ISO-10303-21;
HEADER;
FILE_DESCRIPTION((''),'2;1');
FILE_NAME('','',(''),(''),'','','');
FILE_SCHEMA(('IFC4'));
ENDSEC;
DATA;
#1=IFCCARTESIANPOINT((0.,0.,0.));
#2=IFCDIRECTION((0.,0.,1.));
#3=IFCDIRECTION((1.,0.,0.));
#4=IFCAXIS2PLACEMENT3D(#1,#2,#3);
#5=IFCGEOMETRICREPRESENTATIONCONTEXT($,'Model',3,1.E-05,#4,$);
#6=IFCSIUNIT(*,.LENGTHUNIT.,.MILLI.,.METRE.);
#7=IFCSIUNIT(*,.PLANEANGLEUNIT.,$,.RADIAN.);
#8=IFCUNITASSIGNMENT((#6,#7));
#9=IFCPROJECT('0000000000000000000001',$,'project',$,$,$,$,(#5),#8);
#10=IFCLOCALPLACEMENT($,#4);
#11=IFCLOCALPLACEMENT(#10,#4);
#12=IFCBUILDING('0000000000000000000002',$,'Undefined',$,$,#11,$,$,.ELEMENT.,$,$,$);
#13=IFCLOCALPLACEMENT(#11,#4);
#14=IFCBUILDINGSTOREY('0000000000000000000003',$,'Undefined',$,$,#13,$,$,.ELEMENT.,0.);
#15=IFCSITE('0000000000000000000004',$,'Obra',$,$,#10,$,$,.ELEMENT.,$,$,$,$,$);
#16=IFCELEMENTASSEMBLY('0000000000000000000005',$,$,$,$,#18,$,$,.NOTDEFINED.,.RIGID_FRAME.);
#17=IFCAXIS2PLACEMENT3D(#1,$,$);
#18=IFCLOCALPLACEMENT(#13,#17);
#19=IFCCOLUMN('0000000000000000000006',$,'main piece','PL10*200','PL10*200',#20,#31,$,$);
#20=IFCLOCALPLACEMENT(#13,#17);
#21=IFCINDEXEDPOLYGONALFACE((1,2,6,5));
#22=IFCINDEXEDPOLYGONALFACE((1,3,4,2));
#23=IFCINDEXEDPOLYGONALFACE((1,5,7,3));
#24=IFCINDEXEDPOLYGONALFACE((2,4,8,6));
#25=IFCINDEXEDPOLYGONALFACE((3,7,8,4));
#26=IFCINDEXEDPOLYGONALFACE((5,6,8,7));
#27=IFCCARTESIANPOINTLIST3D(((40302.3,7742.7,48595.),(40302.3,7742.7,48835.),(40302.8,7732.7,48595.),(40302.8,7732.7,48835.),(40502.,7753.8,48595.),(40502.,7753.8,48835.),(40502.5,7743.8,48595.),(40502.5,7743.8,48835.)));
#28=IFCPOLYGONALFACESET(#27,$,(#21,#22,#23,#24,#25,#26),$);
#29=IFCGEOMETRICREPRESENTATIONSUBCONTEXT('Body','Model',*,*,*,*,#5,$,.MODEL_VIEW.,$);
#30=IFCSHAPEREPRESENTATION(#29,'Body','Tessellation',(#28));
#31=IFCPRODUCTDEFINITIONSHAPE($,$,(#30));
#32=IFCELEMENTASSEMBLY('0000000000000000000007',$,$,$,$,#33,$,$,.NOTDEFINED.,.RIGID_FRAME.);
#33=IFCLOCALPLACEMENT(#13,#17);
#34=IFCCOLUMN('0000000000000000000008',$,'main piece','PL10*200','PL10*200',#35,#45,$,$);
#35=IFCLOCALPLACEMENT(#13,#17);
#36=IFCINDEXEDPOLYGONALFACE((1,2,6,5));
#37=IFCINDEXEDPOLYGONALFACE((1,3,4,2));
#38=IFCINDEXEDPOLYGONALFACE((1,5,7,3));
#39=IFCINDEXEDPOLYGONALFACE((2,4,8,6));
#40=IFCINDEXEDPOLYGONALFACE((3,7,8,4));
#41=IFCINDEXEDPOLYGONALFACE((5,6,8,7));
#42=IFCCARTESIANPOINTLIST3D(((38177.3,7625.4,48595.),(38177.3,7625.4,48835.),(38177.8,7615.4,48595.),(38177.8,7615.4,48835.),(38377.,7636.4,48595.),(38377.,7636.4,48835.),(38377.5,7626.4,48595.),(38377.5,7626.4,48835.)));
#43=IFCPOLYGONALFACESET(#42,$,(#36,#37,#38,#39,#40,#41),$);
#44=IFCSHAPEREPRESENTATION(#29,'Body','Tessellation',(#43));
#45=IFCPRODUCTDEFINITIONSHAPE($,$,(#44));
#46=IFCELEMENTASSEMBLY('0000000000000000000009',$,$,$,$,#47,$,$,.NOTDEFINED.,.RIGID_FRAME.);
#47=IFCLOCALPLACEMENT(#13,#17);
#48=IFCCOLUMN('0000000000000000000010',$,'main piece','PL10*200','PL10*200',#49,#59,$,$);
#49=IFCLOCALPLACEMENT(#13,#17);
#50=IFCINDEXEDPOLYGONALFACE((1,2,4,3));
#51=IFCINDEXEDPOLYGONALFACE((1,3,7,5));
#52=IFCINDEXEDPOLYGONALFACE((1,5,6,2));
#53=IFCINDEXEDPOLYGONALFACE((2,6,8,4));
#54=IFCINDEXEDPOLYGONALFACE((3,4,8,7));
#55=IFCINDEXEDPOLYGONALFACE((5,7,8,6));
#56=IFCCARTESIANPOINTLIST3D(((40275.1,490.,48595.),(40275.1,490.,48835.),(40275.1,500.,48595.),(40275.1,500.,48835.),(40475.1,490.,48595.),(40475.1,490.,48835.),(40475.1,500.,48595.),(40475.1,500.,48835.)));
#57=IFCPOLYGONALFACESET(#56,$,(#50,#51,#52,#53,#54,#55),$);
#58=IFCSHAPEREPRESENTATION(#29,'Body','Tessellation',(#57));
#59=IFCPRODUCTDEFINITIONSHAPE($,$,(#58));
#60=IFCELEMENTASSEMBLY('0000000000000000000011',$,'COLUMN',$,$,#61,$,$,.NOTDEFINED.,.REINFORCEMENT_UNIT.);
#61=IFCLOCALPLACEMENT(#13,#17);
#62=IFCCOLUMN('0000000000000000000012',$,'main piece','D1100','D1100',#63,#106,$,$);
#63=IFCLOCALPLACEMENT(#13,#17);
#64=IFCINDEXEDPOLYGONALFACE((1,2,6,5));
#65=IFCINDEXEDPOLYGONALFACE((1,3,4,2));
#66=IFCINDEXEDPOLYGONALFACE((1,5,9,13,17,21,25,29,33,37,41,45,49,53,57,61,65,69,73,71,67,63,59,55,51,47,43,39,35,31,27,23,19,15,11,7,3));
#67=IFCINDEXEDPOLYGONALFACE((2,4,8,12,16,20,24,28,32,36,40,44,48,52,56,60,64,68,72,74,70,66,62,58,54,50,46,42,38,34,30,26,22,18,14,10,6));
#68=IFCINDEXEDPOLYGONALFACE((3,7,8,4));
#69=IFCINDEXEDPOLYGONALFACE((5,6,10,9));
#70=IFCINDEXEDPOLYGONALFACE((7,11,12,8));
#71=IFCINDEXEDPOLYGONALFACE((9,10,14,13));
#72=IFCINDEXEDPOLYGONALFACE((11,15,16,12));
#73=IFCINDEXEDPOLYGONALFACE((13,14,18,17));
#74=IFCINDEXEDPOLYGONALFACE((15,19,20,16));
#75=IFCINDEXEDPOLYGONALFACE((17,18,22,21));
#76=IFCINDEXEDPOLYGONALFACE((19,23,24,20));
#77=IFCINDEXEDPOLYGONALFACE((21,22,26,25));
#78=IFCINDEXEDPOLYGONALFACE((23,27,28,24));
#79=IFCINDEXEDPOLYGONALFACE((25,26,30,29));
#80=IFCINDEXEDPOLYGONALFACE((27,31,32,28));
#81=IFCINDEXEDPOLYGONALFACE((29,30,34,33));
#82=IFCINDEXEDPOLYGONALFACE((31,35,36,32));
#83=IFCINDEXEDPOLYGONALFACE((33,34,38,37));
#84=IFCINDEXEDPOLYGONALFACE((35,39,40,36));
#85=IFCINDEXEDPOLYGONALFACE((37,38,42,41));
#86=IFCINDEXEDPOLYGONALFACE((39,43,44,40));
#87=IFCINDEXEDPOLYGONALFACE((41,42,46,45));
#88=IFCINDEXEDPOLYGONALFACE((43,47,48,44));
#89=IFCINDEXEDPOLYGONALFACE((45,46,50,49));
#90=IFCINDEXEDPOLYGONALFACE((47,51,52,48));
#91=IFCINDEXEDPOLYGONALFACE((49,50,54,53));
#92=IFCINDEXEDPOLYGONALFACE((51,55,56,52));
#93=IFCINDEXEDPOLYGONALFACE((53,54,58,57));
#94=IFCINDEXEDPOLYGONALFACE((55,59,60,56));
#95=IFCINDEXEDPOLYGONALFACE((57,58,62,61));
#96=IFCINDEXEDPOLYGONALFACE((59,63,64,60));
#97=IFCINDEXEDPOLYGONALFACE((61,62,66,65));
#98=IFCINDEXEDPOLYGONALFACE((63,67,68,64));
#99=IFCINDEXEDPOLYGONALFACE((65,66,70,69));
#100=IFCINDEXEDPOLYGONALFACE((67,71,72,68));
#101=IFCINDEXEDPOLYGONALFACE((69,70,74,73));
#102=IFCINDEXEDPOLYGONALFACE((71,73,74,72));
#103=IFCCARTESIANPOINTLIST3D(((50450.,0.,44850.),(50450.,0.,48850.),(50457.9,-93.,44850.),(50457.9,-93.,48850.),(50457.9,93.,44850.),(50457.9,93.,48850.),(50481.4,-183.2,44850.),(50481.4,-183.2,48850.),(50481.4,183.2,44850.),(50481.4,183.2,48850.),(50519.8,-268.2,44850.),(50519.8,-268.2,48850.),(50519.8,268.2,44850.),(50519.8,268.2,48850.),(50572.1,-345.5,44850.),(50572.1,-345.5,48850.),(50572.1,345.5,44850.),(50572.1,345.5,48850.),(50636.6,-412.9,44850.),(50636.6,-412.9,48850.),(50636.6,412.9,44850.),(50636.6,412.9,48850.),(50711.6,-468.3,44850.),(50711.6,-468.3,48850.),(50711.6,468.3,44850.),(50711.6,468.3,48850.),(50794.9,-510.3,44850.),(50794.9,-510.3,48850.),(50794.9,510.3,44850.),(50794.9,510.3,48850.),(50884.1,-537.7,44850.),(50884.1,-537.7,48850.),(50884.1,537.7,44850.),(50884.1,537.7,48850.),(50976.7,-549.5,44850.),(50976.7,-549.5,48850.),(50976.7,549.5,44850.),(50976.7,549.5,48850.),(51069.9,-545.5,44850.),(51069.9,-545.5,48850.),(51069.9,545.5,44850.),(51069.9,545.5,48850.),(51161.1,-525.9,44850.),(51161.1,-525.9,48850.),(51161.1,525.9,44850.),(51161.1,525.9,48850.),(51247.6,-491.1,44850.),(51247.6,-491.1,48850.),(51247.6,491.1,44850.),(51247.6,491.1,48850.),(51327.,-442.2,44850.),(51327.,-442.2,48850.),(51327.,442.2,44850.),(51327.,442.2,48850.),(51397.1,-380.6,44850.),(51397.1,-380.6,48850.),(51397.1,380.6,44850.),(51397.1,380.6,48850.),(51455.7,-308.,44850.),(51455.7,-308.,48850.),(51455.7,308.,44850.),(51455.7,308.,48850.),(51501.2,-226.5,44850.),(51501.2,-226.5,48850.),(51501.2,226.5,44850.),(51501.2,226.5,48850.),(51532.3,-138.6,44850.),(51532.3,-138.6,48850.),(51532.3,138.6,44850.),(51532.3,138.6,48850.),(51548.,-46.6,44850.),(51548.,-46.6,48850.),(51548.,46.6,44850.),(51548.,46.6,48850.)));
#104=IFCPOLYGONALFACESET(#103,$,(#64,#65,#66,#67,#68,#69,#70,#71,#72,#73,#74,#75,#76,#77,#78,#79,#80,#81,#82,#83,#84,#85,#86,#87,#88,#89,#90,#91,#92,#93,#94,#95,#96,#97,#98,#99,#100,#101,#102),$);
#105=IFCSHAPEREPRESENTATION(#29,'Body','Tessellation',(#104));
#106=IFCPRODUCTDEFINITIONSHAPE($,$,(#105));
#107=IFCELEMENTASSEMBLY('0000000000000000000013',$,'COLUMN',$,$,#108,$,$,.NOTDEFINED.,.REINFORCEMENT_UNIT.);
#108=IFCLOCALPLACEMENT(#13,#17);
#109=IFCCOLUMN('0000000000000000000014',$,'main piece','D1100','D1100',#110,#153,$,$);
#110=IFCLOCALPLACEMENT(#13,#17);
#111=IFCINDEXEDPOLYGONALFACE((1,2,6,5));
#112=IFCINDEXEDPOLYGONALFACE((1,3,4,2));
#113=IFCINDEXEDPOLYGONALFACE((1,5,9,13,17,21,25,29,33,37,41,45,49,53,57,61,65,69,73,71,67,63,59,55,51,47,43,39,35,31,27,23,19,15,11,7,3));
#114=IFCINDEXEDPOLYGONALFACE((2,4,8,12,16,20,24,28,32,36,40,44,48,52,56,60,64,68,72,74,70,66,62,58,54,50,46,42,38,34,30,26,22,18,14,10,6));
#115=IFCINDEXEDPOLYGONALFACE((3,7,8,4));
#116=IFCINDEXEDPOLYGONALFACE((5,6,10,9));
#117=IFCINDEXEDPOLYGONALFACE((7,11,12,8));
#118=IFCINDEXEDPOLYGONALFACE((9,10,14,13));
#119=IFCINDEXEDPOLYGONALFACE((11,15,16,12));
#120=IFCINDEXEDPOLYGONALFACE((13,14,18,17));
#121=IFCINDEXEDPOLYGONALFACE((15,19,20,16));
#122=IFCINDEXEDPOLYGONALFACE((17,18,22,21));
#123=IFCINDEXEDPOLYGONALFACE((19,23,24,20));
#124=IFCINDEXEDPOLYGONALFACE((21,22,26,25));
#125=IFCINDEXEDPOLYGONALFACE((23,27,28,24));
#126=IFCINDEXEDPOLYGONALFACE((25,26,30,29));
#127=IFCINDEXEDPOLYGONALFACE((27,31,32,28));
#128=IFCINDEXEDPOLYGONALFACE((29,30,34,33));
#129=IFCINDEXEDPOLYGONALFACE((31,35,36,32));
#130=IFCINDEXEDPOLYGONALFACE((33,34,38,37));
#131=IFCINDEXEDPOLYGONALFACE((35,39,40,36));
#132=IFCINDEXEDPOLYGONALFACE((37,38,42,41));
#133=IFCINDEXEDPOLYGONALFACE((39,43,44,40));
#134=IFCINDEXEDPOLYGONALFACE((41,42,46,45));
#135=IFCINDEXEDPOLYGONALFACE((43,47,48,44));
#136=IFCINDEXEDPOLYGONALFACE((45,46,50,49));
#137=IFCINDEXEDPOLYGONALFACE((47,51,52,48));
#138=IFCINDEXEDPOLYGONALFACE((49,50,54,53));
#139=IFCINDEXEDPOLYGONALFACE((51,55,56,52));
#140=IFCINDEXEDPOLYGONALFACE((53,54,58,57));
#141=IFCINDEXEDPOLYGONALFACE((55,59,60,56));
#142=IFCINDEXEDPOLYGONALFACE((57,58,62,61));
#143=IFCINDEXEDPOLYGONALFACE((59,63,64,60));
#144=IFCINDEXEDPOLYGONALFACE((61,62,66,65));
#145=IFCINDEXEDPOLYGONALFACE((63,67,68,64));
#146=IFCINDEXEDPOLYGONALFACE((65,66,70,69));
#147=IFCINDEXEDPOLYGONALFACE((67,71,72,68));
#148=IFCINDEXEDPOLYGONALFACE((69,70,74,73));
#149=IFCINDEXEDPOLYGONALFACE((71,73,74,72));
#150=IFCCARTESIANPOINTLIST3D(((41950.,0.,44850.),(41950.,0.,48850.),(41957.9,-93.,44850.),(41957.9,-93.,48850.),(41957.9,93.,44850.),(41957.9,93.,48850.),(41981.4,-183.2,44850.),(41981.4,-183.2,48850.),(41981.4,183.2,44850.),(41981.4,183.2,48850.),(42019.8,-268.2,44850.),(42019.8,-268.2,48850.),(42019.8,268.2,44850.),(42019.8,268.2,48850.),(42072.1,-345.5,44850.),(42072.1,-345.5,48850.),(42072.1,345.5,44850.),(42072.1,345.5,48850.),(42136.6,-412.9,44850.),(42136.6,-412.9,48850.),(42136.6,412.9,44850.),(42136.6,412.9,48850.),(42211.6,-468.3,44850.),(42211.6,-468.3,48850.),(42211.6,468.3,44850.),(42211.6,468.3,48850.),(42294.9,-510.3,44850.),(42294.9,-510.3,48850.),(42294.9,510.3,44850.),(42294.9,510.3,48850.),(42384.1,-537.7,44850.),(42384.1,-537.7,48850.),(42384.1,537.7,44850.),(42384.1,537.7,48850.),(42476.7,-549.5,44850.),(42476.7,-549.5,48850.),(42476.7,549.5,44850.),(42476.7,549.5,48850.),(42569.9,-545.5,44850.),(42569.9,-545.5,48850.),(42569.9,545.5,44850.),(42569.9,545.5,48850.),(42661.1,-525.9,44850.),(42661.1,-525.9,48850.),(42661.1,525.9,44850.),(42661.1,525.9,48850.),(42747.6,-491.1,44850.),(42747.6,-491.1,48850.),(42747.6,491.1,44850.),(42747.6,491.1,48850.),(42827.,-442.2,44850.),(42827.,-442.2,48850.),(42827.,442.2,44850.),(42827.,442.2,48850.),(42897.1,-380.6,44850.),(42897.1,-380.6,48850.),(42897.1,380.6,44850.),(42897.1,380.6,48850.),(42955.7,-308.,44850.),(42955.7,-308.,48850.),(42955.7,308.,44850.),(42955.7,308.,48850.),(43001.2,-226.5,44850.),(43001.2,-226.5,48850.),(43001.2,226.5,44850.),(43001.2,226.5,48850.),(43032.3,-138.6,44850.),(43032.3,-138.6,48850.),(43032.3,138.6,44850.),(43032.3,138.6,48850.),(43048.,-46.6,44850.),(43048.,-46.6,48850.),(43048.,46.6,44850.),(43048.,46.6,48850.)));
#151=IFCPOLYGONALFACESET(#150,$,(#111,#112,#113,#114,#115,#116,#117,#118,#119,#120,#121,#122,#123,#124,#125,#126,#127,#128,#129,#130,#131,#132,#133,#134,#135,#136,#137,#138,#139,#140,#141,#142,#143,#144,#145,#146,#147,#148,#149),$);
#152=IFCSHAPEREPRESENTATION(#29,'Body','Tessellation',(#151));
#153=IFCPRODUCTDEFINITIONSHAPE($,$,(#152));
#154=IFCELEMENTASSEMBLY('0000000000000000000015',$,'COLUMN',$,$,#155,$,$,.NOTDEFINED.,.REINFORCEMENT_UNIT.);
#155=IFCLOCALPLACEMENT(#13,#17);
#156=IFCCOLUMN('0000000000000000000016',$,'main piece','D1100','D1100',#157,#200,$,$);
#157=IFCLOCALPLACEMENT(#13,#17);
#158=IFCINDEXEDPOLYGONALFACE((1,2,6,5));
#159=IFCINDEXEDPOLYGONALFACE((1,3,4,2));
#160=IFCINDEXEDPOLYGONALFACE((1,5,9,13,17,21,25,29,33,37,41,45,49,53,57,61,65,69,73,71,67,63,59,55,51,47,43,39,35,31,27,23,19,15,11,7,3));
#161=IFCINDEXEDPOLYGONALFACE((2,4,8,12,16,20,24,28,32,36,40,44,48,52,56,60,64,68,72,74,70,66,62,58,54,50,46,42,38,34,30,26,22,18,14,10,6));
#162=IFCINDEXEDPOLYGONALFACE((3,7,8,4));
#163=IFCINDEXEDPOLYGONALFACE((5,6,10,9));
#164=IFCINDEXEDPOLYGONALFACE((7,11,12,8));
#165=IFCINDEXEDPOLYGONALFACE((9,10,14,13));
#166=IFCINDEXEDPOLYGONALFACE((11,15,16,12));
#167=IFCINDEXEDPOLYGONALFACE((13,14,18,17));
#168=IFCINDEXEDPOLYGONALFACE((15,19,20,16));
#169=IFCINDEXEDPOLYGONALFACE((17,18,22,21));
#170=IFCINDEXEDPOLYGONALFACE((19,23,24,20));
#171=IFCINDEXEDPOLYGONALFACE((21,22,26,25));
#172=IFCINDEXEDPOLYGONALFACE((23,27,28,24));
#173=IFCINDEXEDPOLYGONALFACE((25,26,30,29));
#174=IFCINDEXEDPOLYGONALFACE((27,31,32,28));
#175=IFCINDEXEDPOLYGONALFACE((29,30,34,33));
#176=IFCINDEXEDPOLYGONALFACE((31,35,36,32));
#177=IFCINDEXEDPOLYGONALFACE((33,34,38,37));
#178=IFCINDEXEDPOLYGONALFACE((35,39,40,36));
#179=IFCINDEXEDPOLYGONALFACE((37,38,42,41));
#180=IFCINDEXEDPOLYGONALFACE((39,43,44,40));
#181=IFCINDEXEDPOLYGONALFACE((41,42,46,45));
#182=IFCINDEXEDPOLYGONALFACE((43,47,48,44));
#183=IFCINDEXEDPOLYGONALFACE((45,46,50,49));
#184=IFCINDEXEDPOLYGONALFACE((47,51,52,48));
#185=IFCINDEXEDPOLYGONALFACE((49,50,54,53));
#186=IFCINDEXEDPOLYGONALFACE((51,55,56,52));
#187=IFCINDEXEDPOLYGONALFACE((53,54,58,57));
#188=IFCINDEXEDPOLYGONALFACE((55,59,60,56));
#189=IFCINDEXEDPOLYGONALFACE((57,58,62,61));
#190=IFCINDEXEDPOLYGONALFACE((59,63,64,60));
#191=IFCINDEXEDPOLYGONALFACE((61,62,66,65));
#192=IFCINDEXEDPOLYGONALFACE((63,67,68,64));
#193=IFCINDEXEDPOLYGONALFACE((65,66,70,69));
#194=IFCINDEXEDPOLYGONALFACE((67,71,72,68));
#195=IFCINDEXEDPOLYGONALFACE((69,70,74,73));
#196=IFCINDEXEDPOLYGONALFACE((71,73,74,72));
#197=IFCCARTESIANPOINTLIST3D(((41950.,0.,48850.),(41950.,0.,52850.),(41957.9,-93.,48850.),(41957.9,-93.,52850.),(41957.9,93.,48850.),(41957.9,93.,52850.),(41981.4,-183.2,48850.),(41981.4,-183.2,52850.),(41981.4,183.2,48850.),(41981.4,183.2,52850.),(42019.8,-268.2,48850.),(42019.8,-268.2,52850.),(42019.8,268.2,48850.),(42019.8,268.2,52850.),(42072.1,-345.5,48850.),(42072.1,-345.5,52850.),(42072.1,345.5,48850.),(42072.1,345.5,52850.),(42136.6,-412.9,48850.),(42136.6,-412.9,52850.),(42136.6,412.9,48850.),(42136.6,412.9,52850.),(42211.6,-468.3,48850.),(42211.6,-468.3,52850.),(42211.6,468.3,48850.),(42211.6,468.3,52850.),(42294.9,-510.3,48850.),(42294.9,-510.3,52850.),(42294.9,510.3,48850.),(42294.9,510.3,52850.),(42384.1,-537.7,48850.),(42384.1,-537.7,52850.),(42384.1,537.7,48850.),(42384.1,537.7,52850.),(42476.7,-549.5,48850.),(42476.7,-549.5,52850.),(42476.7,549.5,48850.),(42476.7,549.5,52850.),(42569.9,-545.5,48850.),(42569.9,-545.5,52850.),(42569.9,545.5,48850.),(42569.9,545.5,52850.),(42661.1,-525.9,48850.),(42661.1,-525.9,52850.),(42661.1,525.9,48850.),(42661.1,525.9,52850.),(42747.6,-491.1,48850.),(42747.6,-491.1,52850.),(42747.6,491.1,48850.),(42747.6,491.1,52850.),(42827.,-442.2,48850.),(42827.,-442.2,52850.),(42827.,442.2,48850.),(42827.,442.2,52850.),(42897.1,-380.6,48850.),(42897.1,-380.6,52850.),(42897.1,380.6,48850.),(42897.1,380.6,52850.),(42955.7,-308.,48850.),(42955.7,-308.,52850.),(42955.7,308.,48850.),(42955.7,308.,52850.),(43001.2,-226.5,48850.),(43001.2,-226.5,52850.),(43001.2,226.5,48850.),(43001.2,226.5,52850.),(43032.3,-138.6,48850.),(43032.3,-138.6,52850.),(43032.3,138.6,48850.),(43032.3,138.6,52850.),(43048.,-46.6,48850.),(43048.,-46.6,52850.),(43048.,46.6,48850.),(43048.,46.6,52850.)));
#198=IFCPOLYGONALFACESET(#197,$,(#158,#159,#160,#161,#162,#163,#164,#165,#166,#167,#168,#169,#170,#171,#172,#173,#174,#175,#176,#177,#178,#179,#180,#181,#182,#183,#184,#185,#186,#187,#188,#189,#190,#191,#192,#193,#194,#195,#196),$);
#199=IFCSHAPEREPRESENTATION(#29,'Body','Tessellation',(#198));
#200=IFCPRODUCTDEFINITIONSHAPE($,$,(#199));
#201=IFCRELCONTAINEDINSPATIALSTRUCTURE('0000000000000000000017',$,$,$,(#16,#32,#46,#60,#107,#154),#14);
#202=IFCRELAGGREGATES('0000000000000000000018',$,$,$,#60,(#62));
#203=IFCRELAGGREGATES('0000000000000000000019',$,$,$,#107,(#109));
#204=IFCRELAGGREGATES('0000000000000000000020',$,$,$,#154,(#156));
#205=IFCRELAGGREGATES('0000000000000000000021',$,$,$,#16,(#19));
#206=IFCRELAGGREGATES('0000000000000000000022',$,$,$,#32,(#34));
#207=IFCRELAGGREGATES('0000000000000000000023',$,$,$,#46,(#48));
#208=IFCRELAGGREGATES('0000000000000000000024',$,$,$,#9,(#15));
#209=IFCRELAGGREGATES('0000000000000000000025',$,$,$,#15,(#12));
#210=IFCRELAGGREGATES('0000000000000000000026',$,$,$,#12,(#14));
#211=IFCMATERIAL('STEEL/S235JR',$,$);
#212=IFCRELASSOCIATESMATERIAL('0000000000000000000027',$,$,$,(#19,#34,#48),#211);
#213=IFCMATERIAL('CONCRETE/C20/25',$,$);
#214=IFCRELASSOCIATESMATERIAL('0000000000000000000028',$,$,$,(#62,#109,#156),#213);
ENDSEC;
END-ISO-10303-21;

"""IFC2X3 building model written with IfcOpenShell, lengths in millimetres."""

from ifc_helpers import new_model, si_unit, frame, origin_with_axes, origin_2d_with_axis, place, context, subcontext, project, spatial, rectangle, circle, extrude, material, element, aggregate, save


model = new_model("IFC2X3")

# Units and contexts
model_context = context("Model", 3, precision=1e-05, world=origin_with_axes())
body_context = subcontext(model_context, "Body", "Model", "MODEL_VIEW")
ifc_project = project(units=[si_unit("LENGTHUNIT", "METRE", prefix="MILLI"), si_unit("PLANEANGLEUNIT", "RADIAN")], contexts=[model_context])

# Site, building, storey
site_placement = place(None, origin_with_axes())
site = spatial("IfcSite", under=ifc_project, at=site_placement, Name="Obra", CompositionType="ELEMENT")
building_placement = place(site_placement, origin_with_axes())
building = spatial("IfcBuilding", under=site, at=building_placement, Name="Undefined", CompositionType="ELEMENT")
storey_placement = place(building_placement, origin_with_axes())
storey = spatial("IfcBuildingStorey", under=building, at=storey_placement, Name="Undefined", CompositionType="ELEMENT", Elevation=0.0)

# Element assemblies, columns
assembly_1_placement = place(storey_placement, origin_with_axes())
assembly_1 = element("IfcElementAssembly", 1, at=assembly_1_placement, inside=storey, AssemblyPlace="NOTDEFINED", PredefinedType="RIGID_FRAME")
ifc_material_1 = material(Name="STEEL/S235JR")
column_1_placement = place(assembly_1_placement, frame((40402.4, 7743.3, 48595.0), z_axis=(0.0, 0.0, 1.0), x_axis=(-0.998478, -0.055152, 0.0)))
column_1 = element("IfcColumn", 2, at=column_1_placement, material=ifc_material_1, Name="main piece", Description="PL10*200", ObjectType="PL10*200", context=body_context, shape_type="SweptSolid", body=[
    extrude(rectangle(XDim=10.0, YDim=200.0, at=origin_2d_with_axis()), frame((0.0, 0.0, 240.0), z_axis=(0.0, 0.0, -1.0), x_axis=(0.0, 1.0, 0.0)), (0.0, 0.0, 1.0), 240.0),
])
assembly_2_placement = place(storey_placement, origin_with_axes())
assembly_2 = element("IfcElementAssembly", 3, at=assembly_2_placement, inside=storey, AssemblyPlace="NOTDEFINED", PredefinedType="RIGID_FRAME")
column_2_placement = place(assembly_2_placement, frame((38277.4, 7625.9, 48595.0), z_axis=(0.0, 0.0, 1.0), x_axis=(-0.998478, -0.055152, 0.0)))
column_2 = element("IfcColumn", 4, at=column_2_placement, material=ifc_material_1, Name="main piece", Description="PL10*200", ObjectType="PL10*200", context=body_context, shape_type="SweptSolid", body=[
    extrude(rectangle(XDim=10.0, YDim=200.0, at=origin_2d_with_axis()), frame((0.0, 0.0, 240.0), z_axis=(0.0, 0.0, -1.0), x_axis=(0.0, 1.0, 0.0)), (0.0, 0.0, 1.0), 240.0),
])
assembly_3_placement = place(storey_placement, origin_with_axes())
assembly_3 = element("IfcElementAssembly", 5, at=assembly_3_placement, inside=storey, AssemblyPlace="NOTDEFINED", PredefinedType="RIGID_FRAME")
column_3_placement = place(assembly_3_placement, frame((40375.1, 495.0, 48595.0), z_axis=(0.0, 0.0, 1.0), x_axis=(1.0, 0.000002, 0.0)))
column_3 = element("IfcColumn", 6, at=column_3_placement, material=ifc_material_1, Name="main piece", Description="PL10*200", ObjectType="PL10*200", context=body_context, shape_type="SweptSolid", body=[
    extrude(rectangle(XDim=10.0, YDim=200.0, at=origin_2d_with_axis()), frame((0.0, 0.0, 240.0), z_axis=(0.0, 0.0, -1.0), x_axis=(0.0, 1.0, 0.0)), (0.0, 0.0, 1.0), 240.0),
])
assembly_4_placement = place(storey_placement, origin_with_axes())
assembly_4 = element("IfcElementAssembly", 7, at=assembly_4_placement, inside=storey, Name="COLUMN", AssemblyPlace="NOTDEFINED", PredefinedType="REINFORCEMENT_UNIT")
ifc_material_2 = material(Name="CONCRETE/C20/25")
column_4_placement = place(assembly_4_placement, frame((51000.0, 0.0, 44850.0), z_axis=(0.0, 0.0, 1.0), x_axis=(0.0, 1.0, 0.0)))
column_4 = element("IfcColumn", 8, at=column_4_placement, material=ifc_material_2, Name="main piece", Description="D1100", ObjectType="D1100", context=body_context, shape_type="SweptSolid", body=[
    extrude(circle(Radius=550.0, at=origin_2d_with_axis()), frame((0.0, 0.0, 4000.0), z_axis=(0.0, 0.0, -1.0), x_axis=(0.0, 1.0, 0.0)), (0.0, 0.0, 1.0), 4000.0),
])
aggregate(assembly_4, [column_4])
assembly_5_placement = place(storey_placement, origin_with_axes())
assembly_5 = element("IfcElementAssembly", 9, at=assembly_5_placement, inside=storey, Name="COLUMN", AssemblyPlace="NOTDEFINED", PredefinedType="REINFORCEMENT_UNIT")
column_5_placement = place(assembly_5_placement, frame((42500.0, 0.0, 44850.0), z_axis=(0.0, 0.0, 1.0), x_axis=(0.0, 1.0, 0.0)))
column_5 = element("IfcColumn", 10, at=column_5_placement, material=ifc_material_2, Name="main piece", Description="D1100", ObjectType="D1100", context=body_context, shape_type="SweptSolid", body=[
    extrude(circle(Radius=550.0, at=origin_2d_with_axis()), frame((0.0, 0.0, 4000.0), z_axis=(0.0, 0.0, -1.0), x_axis=(0.0, 1.0, 0.0)), (0.0, 0.0, 1.0), 4000.0),
])
aggregate(assembly_5, [column_5])
assembly_6_placement = place(storey_placement, origin_with_axes())
assembly_6 = element("IfcElementAssembly", 11, at=assembly_6_placement, inside=storey, Name="COLUMN", AssemblyPlace="NOTDEFINED", PredefinedType="REINFORCEMENT_UNIT")
column_6_placement = place(assembly_6_placement, frame((42500.0, 0.0, 48850.0), z_axis=(0.0, 0.0, 1.0), x_axis=(0.0, 1.0, 0.0)))
column_6 = element("IfcColumn", 12, at=column_6_placement, material=ifc_material_2, Name="main piece", Description="D1100", ObjectType="D1100", context=body_context, shape_type="SweptSolid", body=[
    extrude(circle(Radius=550.0, at=origin_2d_with_axis()), frame((0.0, 0.0, 4000.0), z_axis=(0.0, 0.0, -1.0), x_axis=(0.0, 1.0, 0.0)), (0.0, 0.0, 1.0), 4000.0),
])
aggregate(assembly_6, [column_6])

aggregate(assembly_1, [column_1])
aggregate(assembly_2, [column_2])
aggregate(assembly_3, [column_3])

save(model, "model.ifc")
